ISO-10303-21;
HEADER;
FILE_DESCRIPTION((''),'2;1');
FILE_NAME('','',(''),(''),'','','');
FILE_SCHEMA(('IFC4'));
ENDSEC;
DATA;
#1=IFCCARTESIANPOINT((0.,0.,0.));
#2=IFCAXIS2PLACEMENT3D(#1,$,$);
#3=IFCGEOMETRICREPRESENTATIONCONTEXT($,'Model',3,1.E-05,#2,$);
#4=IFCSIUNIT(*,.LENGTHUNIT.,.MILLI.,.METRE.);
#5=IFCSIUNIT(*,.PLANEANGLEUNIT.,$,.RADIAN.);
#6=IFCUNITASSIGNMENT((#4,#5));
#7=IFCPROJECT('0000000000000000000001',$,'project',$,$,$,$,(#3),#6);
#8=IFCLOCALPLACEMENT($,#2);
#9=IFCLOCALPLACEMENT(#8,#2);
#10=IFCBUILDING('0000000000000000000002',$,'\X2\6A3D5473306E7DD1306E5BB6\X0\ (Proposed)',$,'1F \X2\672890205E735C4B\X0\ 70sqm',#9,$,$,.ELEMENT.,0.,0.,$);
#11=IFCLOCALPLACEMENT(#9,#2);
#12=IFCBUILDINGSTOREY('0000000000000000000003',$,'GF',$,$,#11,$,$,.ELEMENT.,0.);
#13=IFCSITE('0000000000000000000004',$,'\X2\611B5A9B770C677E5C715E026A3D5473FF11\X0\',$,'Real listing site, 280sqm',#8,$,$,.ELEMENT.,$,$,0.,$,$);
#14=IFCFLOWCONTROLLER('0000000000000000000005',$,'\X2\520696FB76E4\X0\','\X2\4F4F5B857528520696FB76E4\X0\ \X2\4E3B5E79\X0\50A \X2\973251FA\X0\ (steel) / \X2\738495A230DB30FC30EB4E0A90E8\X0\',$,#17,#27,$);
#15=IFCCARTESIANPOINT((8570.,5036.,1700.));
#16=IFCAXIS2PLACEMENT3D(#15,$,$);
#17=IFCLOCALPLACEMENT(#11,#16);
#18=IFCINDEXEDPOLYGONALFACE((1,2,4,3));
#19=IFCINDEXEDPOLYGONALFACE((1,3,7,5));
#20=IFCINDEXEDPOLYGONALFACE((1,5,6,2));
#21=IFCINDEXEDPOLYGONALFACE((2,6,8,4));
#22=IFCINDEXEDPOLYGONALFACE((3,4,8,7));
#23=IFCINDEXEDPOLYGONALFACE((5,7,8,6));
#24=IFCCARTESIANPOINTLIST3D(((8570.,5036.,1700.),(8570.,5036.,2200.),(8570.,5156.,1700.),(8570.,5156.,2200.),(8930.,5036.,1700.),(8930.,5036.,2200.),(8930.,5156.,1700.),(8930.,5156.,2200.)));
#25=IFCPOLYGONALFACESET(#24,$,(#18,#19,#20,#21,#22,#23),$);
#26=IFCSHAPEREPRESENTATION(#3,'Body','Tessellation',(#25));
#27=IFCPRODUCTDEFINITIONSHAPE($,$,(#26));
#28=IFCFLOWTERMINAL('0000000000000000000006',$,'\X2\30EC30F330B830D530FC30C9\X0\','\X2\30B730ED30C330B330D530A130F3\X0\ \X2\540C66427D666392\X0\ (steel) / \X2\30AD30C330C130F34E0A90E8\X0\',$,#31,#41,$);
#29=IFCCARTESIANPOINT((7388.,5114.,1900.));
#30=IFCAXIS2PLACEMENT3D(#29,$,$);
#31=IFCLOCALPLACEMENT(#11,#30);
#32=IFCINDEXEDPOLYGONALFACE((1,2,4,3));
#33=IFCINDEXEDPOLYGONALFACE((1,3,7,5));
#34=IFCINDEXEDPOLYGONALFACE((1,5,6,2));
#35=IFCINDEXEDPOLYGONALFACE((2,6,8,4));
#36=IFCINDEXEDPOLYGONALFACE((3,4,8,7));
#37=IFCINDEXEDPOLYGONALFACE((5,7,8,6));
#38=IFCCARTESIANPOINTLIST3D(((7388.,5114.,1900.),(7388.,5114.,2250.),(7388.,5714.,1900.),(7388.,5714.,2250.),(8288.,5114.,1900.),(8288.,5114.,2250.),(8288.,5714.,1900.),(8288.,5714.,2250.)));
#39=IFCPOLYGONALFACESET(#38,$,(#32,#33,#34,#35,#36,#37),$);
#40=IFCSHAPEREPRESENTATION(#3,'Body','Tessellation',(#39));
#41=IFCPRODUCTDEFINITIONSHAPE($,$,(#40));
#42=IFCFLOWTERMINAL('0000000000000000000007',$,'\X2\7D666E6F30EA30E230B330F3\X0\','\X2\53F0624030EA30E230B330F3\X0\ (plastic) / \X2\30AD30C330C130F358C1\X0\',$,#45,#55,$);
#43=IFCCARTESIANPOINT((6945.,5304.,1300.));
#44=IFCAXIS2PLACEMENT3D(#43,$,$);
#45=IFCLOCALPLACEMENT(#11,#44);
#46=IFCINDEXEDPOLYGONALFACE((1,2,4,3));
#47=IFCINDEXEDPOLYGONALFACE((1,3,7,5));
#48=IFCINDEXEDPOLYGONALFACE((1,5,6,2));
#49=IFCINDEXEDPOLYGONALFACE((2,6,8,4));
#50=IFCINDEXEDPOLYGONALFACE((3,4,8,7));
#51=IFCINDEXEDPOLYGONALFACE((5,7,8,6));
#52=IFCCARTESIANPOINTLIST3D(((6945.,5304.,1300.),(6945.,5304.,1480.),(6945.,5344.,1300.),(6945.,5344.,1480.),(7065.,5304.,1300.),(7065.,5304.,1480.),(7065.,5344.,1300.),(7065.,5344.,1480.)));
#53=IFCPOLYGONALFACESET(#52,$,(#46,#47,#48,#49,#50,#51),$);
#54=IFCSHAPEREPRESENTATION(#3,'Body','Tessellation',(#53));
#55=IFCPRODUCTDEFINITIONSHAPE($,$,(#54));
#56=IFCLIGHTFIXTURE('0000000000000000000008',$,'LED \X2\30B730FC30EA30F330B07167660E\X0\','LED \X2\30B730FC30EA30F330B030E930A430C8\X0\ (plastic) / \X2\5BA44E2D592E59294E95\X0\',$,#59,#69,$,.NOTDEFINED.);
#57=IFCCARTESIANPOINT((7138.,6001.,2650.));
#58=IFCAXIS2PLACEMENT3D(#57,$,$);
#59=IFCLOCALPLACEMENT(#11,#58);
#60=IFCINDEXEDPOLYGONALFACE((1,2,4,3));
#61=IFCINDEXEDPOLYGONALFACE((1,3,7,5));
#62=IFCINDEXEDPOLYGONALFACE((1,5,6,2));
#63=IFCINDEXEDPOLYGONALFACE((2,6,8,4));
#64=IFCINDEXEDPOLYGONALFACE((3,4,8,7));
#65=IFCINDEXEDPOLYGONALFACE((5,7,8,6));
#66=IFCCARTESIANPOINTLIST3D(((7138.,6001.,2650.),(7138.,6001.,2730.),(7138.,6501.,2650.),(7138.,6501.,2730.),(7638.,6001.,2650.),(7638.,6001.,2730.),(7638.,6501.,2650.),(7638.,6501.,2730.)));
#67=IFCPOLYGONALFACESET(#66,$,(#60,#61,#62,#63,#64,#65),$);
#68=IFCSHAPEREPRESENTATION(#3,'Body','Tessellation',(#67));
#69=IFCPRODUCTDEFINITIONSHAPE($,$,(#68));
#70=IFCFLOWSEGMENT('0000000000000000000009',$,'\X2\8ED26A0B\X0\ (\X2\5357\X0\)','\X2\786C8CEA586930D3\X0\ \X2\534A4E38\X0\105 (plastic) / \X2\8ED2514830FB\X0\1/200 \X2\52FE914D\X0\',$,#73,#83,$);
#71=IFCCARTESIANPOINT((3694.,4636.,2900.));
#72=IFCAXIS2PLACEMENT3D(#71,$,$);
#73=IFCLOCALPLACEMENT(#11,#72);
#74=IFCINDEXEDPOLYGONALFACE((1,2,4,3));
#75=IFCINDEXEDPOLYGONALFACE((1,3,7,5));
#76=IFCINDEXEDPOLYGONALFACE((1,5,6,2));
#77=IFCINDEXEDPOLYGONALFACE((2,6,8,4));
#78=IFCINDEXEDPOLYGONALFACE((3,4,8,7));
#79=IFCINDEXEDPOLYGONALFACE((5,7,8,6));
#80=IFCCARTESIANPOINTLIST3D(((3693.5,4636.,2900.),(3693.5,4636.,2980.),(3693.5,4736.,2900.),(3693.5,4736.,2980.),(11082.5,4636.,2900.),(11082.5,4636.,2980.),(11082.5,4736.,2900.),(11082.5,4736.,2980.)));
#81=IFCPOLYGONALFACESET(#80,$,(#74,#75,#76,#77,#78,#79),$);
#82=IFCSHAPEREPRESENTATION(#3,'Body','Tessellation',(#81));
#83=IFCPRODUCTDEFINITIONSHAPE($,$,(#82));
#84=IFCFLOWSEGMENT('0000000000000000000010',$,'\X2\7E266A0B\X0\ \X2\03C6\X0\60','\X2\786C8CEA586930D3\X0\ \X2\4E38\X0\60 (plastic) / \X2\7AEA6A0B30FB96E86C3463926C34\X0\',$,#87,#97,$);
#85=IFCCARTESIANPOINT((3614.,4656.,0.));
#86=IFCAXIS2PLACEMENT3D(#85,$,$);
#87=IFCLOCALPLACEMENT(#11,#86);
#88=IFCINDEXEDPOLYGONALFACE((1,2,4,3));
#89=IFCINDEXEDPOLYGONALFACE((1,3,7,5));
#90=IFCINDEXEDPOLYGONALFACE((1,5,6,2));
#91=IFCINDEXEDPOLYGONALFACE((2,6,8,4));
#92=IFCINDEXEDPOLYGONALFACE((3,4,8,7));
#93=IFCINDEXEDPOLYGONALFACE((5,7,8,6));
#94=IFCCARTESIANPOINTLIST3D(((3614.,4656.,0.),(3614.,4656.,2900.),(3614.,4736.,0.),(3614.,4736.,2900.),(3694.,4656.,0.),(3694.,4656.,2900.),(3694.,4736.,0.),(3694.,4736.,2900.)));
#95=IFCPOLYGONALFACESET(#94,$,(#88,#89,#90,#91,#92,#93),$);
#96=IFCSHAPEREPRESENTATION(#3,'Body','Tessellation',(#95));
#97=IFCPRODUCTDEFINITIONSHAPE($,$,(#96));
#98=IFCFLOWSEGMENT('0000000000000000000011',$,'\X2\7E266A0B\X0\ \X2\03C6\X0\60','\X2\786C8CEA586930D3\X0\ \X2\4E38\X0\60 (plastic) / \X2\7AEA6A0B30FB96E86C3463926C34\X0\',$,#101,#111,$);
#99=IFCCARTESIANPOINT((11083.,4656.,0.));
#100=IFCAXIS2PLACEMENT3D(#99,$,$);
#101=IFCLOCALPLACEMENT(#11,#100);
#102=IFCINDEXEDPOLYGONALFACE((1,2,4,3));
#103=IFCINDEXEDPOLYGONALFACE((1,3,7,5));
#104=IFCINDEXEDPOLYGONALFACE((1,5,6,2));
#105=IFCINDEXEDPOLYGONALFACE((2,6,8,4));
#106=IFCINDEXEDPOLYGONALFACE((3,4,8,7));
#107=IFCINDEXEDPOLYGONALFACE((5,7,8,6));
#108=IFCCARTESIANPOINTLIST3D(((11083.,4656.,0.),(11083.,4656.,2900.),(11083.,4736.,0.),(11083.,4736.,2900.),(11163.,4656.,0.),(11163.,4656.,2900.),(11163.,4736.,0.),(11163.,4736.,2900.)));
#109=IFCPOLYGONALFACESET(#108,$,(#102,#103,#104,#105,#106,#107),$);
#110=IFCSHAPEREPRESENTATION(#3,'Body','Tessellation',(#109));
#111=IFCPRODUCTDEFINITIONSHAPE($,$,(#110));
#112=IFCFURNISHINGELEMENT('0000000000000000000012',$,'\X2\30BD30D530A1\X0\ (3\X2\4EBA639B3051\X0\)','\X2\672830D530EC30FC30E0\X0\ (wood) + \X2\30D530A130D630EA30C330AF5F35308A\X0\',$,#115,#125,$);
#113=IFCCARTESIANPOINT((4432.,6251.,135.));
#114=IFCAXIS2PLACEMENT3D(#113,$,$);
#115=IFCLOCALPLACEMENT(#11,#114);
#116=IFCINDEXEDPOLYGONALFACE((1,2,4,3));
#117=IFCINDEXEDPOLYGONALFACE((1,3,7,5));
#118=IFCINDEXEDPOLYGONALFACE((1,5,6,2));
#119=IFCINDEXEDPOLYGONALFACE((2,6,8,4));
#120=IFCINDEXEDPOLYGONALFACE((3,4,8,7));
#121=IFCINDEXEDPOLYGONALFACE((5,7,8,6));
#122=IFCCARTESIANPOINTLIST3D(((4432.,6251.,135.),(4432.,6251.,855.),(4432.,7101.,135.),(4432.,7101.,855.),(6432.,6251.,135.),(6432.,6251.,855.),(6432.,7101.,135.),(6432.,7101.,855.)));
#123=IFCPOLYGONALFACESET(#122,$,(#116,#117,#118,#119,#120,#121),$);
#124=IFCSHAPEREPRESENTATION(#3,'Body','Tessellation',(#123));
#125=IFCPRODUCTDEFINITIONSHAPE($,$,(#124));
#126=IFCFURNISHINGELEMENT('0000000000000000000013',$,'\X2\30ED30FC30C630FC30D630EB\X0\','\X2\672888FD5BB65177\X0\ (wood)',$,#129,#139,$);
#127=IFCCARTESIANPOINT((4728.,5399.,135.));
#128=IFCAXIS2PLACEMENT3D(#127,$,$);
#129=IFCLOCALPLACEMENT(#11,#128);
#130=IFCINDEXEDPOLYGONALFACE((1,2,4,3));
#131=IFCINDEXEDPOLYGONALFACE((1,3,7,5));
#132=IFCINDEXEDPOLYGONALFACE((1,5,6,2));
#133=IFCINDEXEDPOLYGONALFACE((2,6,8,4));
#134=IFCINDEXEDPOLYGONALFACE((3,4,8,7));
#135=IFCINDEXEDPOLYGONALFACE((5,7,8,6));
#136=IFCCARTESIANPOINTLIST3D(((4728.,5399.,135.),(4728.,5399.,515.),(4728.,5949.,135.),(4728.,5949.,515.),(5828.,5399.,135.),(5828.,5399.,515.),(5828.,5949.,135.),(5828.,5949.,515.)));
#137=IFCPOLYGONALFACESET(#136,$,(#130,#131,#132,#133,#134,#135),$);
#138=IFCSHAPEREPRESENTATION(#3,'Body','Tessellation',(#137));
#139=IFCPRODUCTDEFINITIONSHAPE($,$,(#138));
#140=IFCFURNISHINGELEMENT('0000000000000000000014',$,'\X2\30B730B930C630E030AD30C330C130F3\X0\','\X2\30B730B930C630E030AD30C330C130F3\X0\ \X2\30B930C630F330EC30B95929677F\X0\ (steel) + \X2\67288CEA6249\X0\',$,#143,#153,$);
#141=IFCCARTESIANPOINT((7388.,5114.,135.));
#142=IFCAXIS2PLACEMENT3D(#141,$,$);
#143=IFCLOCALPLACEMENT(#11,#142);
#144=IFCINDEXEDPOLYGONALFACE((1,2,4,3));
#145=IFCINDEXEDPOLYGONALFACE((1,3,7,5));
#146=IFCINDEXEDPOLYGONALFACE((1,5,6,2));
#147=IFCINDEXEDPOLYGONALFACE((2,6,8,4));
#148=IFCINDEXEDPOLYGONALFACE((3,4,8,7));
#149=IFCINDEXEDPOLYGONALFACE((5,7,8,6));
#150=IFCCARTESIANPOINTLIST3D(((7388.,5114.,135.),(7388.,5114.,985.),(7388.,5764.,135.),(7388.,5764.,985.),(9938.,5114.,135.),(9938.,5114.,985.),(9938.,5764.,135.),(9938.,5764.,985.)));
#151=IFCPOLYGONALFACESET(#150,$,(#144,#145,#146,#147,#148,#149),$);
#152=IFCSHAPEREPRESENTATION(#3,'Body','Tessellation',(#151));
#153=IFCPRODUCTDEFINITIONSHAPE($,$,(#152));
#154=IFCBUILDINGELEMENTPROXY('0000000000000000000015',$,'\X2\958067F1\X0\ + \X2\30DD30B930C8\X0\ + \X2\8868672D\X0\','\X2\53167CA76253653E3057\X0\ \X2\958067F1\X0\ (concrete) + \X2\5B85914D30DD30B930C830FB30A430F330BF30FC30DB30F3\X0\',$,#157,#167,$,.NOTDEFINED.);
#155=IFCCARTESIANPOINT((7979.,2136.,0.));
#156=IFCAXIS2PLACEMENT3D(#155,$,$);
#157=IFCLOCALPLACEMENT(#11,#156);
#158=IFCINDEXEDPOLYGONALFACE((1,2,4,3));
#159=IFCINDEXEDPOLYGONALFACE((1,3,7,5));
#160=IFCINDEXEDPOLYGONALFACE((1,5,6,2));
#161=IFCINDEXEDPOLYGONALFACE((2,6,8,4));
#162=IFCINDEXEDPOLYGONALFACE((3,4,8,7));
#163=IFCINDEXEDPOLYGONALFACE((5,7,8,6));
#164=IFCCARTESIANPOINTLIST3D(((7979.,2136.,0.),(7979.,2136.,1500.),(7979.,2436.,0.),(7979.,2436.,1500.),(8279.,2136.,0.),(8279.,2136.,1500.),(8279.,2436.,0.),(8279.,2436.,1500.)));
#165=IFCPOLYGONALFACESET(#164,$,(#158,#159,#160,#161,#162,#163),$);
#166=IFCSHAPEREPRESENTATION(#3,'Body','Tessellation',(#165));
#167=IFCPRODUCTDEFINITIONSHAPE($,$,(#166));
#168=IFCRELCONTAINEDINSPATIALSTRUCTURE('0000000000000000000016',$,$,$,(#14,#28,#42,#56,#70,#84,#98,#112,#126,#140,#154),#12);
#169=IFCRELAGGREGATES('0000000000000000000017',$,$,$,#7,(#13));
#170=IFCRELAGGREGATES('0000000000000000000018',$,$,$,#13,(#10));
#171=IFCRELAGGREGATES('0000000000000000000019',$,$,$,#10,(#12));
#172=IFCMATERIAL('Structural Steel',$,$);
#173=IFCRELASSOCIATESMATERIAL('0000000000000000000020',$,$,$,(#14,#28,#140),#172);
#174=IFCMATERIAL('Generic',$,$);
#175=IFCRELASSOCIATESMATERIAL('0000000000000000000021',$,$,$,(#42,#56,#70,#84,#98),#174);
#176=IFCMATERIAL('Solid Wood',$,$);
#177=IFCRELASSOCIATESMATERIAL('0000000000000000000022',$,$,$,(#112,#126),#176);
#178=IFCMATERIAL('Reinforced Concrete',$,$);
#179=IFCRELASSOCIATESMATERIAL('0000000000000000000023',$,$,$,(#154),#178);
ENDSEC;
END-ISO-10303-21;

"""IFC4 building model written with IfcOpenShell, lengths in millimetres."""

from ifc_helpers import new_model, si_unit, frame, frame_2d, origin, place, context, project, spatial, rectangle, extrude, material, element, save


model = new_model("IFC4")

# Units and contexts
model_context = context("Model", 3, precision=1e-05, world=origin())
ifc_project = project(units=[si_unit("LENGTHUNIT", "METRE", prefix="MILLI"), si_unit("PLANEANGLEUNIT", "RADIAN")], contexts=[model_context])

# Site, building, storey
site_placement = place(None, origin())
site = spatial("IfcSite", under=ifc_project, at=site_placement, Name="愛媛県松山市樽味１", ObjectType="Real listing site, 280sqm", CompositionType="ELEMENT", RefElevation=0.0)
building_placement = place(site_placement, origin())
building = spatial("IfcBuilding", under=site, at=building_placement, Name="樽味の緑の家 (Proposed)", ObjectType="1F 木造平屋 70sqm", CompositionType="ELEMENT", ElevationOfRefHeight=0.0, ElevationOfTerrain=0.0)
storey_placement = place(building_placement, origin())
storey = spatial("IfcBuildingStorey", under=building, at=storey_placement, Name="GF", CompositionType="ELEMENT", Elevation=0.0)

# Shared definitions
ifc_material_1 = material(Name="Solid Wood")

# Shared definitions
ifc_material_2 = material(Name="Reinforced Concrete")

# Shared definitions
ifc_material_3 = material(Name="Structural Steel")

# Shared definitions
ifc_material_4 = material(Name="Generic")

# Flow controller
flow_controller_placement = place(storey_placement, frame((8570.0, 5036.0, 1700.0)))
element("IfcFlowController", 1, at=flow_controller_placement, inside=storey, material=ifc_material_3, Name="分電盤", Description="住宅用分電盤 主幹50A 露出 (steel) / 玄関ホール上部", context=model_context, shape_type="SweptSolid", body=[
    extrude(rectangle(XDim=360.0, YDim=120.0, at=frame_2d((180.0, 60.0))), frame((8570.0, 5036.0, 1700.0)), (0.0, 0.0, 1.0), 500.0),
])

# Flow terminals
flow_terminal_1_placement = place(storey_placement, frame((7388.0, 5114.0, 1900.0)))
element("IfcFlowTerminal", 2, at=flow_terminal_1_placement, inside=storey, material=ifc_material_3, Name="レンジフード", Description="シロッコファン 同時給排 (steel) / キッチン上部", context=model_context, shape_type="SweptSolid", body=[
    extrude(rectangle(XDim=900.0, YDim=600.0, at=frame_2d((450.0, 300.0))), frame((7388.0, 5114.0, 1900.0)), (0.0, 0.0, 1.0), 350.0),
])
flow_terminal_2_placement = place(storey_placement, frame((6945.0, 5304.0, 1300.0)))
element("IfcFlowTerminal", 3, at=flow_terminal_2_placement, inside=storey, material=ifc_material_4, Name="給湯リモコン", Description="台所リモコン (plastic) / キッチン壁", context=model_context, shape_type="SweptSolid", body=[
    extrude(rectangle(XDim=120.0, YDim=40.0, at=frame_2d((60.0, 20.0))), frame((6945.0, 5304.0, 1300.0)), (0.0, 0.0, 1.0), 180.0),
])

# Light fixture
light_fixture_placement = place(storey_placement, frame((7138.0, 6001.0, 2650.0)))
element("IfcLightFixture", 4, at=light_fixture_placement, inside=storey, material=ifc_material_4, Name="LED シーリング照明", Description="LED シーリングライト (plastic) / 室中央天井", PredefinedType="NOTDEFINED", context=model_context, shape_type="SweptSolid", body=[
    extrude(rectangle(XDim=500.0, YDim=500.0, at=frame_2d((250.0, 250.0))), frame((7138.0, 6001.0, 2650.0)), (0.0, 0.0, 1.0), 80.0),
])

# Flow segments
flow_segment_1_placement = place(storey_placement, frame((3694.0, 4636.0, 2900.0)))
element("IfcFlowSegment", 5, at=flow_segment_1_placement, inside=storey, material=ifc_material_4, Name="軒樋 (南)", Description="硬質塩ビ 半丸105 (plastic) / 軒先・1/200 勾配", context=model_context, shape_type="SweptSolid", body=[
    extrude(rectangle(XDim=7389.0, YDim=100.0, at=frame_2d((3694.0, 50.0))), frame((3694.0, 4636.0, 2900.0)), (0.0, 0.0, 1.0), 80.0),
])
flow_segment_2_placement = place(storey_placement, frame((3614.0, 4656.0, 0.0)))
element("IfcFlowSegment", 6, at=flow_segment_2_placement, inside=storey, material=ifc_material_4, Name="縦樋 φ60", Description="硬質塩ビ 丸60 (plastic) / 竪樋・雨水排水", context=model_context, shape_type="SweptSolid", body=[
    extrude(rectangle(XDim=80.0, YDim=80.0, at=frame_2d((40.0, 40.0))), frame((3614.0, 4656.0, 0.0)), (0.0, 0.0, 1.0), 2900.0),
])
flow_segment_3_placement = place(storey_placement, frame((11083.0, 4656.0, 0.0)))
element("IfcFlowSegment", 7, at=flow_segment_3_placement, inside=storey, material=ifc_material_4, Name="縦樋 φ60", Description="硬質塩ビ 丸60 (plastic) / 竪樋・雨水排水", context=model_context, shape_type="SweptSolid", body=[
    extrude(rectangle(XDim=80.0, YDim=80.0, at=frame_2d((40.0, 40.0))), frame((11083.0, 4656.0, 0.0)), (0.0, 0.0, 1.0), 2900.0),
])

# Furnishing elements
furnishing_1_placement = place(storey_placement, frame((4432.0, 6251.0, 135.0)))
element("IfcFurnishingElement", 8, at=furnishing_1_placement, inside=storey, material=ifc_material_1, Name="ソファ (3人掛け)", Description="木フレーム (wood) + ファブリック張り", context=model_context, shape_type="SweptSolid", body=[
    extrude(rectangle(XDim=2000.0, YDim=850.0, at=frame_2d((1000.0, 425.0))), frame((4432.0, 6251.0, 135.0)), (0.0, 0.0, 1.0), 720.0),
])
furnishing_2_placement = place(storey_placement, frame((4728.0, 5399.0, 135.0)))
element("IfcFurnishingElement", 9, at=furnishing_2_placement, inside=storey, material=ifc_material_1, Name="ローテーブル", Description="木製家具 (wood)", context=model_context, shape_type="SweptSolid", body=[
    extrude(rectangle(XDim=1100.0, YDim=550.0, at=frame_2d((550.0, 275.0))), frame((4728.0, 5399.0, 135.0)), (0.0, 0.0, 1.0), 380.0),
])
furnishing_3_placement = place(storey_placement, frame((7388.0, 5114.0, 135.0)))
element("IfcFurnishingElement", 10, at=furnishing_3_placement, inside=storey, material=ifc_material_3, Name="システムキッチン", Description="システムキッチン ステンレス天板 (steel) + 木質扉", context=model_context, shape_type="SweptSolid", body=[
    extrude(rectangle(XDim=2550.0, YDim=650.0, at=frame_2d((1275.0, 325.0))), frame((7388.0, 5114.0, 135.0)), (0.0, 0.0, 1.0), 850.0),
])

# Building element proxy
proxy_placement = place(storey_placement, frame((7979.0, 2136.0, 0.0)))
element("IfcBuildingElementProxy", 11, at=proxy_placement, inside=storey, material=ifc_material_2, Name="門柱 + ポスト + 表札", Description="化粧打放し 門柱 (concrete) + 宅配ポスト・インターホン", PredefinedType="NOTDEFINED", context=model_context, shape_type="SweptSolid", body=[
    extrude(rectangle(XDim=300.0, YDim=300.0, at=frame_2d((150.0, 150.0))), frame((7979.0, 2136.0, 0.0)), (0.0, 0.0, 1.0), 1500.0),
])

save(model, "model.ifc")
